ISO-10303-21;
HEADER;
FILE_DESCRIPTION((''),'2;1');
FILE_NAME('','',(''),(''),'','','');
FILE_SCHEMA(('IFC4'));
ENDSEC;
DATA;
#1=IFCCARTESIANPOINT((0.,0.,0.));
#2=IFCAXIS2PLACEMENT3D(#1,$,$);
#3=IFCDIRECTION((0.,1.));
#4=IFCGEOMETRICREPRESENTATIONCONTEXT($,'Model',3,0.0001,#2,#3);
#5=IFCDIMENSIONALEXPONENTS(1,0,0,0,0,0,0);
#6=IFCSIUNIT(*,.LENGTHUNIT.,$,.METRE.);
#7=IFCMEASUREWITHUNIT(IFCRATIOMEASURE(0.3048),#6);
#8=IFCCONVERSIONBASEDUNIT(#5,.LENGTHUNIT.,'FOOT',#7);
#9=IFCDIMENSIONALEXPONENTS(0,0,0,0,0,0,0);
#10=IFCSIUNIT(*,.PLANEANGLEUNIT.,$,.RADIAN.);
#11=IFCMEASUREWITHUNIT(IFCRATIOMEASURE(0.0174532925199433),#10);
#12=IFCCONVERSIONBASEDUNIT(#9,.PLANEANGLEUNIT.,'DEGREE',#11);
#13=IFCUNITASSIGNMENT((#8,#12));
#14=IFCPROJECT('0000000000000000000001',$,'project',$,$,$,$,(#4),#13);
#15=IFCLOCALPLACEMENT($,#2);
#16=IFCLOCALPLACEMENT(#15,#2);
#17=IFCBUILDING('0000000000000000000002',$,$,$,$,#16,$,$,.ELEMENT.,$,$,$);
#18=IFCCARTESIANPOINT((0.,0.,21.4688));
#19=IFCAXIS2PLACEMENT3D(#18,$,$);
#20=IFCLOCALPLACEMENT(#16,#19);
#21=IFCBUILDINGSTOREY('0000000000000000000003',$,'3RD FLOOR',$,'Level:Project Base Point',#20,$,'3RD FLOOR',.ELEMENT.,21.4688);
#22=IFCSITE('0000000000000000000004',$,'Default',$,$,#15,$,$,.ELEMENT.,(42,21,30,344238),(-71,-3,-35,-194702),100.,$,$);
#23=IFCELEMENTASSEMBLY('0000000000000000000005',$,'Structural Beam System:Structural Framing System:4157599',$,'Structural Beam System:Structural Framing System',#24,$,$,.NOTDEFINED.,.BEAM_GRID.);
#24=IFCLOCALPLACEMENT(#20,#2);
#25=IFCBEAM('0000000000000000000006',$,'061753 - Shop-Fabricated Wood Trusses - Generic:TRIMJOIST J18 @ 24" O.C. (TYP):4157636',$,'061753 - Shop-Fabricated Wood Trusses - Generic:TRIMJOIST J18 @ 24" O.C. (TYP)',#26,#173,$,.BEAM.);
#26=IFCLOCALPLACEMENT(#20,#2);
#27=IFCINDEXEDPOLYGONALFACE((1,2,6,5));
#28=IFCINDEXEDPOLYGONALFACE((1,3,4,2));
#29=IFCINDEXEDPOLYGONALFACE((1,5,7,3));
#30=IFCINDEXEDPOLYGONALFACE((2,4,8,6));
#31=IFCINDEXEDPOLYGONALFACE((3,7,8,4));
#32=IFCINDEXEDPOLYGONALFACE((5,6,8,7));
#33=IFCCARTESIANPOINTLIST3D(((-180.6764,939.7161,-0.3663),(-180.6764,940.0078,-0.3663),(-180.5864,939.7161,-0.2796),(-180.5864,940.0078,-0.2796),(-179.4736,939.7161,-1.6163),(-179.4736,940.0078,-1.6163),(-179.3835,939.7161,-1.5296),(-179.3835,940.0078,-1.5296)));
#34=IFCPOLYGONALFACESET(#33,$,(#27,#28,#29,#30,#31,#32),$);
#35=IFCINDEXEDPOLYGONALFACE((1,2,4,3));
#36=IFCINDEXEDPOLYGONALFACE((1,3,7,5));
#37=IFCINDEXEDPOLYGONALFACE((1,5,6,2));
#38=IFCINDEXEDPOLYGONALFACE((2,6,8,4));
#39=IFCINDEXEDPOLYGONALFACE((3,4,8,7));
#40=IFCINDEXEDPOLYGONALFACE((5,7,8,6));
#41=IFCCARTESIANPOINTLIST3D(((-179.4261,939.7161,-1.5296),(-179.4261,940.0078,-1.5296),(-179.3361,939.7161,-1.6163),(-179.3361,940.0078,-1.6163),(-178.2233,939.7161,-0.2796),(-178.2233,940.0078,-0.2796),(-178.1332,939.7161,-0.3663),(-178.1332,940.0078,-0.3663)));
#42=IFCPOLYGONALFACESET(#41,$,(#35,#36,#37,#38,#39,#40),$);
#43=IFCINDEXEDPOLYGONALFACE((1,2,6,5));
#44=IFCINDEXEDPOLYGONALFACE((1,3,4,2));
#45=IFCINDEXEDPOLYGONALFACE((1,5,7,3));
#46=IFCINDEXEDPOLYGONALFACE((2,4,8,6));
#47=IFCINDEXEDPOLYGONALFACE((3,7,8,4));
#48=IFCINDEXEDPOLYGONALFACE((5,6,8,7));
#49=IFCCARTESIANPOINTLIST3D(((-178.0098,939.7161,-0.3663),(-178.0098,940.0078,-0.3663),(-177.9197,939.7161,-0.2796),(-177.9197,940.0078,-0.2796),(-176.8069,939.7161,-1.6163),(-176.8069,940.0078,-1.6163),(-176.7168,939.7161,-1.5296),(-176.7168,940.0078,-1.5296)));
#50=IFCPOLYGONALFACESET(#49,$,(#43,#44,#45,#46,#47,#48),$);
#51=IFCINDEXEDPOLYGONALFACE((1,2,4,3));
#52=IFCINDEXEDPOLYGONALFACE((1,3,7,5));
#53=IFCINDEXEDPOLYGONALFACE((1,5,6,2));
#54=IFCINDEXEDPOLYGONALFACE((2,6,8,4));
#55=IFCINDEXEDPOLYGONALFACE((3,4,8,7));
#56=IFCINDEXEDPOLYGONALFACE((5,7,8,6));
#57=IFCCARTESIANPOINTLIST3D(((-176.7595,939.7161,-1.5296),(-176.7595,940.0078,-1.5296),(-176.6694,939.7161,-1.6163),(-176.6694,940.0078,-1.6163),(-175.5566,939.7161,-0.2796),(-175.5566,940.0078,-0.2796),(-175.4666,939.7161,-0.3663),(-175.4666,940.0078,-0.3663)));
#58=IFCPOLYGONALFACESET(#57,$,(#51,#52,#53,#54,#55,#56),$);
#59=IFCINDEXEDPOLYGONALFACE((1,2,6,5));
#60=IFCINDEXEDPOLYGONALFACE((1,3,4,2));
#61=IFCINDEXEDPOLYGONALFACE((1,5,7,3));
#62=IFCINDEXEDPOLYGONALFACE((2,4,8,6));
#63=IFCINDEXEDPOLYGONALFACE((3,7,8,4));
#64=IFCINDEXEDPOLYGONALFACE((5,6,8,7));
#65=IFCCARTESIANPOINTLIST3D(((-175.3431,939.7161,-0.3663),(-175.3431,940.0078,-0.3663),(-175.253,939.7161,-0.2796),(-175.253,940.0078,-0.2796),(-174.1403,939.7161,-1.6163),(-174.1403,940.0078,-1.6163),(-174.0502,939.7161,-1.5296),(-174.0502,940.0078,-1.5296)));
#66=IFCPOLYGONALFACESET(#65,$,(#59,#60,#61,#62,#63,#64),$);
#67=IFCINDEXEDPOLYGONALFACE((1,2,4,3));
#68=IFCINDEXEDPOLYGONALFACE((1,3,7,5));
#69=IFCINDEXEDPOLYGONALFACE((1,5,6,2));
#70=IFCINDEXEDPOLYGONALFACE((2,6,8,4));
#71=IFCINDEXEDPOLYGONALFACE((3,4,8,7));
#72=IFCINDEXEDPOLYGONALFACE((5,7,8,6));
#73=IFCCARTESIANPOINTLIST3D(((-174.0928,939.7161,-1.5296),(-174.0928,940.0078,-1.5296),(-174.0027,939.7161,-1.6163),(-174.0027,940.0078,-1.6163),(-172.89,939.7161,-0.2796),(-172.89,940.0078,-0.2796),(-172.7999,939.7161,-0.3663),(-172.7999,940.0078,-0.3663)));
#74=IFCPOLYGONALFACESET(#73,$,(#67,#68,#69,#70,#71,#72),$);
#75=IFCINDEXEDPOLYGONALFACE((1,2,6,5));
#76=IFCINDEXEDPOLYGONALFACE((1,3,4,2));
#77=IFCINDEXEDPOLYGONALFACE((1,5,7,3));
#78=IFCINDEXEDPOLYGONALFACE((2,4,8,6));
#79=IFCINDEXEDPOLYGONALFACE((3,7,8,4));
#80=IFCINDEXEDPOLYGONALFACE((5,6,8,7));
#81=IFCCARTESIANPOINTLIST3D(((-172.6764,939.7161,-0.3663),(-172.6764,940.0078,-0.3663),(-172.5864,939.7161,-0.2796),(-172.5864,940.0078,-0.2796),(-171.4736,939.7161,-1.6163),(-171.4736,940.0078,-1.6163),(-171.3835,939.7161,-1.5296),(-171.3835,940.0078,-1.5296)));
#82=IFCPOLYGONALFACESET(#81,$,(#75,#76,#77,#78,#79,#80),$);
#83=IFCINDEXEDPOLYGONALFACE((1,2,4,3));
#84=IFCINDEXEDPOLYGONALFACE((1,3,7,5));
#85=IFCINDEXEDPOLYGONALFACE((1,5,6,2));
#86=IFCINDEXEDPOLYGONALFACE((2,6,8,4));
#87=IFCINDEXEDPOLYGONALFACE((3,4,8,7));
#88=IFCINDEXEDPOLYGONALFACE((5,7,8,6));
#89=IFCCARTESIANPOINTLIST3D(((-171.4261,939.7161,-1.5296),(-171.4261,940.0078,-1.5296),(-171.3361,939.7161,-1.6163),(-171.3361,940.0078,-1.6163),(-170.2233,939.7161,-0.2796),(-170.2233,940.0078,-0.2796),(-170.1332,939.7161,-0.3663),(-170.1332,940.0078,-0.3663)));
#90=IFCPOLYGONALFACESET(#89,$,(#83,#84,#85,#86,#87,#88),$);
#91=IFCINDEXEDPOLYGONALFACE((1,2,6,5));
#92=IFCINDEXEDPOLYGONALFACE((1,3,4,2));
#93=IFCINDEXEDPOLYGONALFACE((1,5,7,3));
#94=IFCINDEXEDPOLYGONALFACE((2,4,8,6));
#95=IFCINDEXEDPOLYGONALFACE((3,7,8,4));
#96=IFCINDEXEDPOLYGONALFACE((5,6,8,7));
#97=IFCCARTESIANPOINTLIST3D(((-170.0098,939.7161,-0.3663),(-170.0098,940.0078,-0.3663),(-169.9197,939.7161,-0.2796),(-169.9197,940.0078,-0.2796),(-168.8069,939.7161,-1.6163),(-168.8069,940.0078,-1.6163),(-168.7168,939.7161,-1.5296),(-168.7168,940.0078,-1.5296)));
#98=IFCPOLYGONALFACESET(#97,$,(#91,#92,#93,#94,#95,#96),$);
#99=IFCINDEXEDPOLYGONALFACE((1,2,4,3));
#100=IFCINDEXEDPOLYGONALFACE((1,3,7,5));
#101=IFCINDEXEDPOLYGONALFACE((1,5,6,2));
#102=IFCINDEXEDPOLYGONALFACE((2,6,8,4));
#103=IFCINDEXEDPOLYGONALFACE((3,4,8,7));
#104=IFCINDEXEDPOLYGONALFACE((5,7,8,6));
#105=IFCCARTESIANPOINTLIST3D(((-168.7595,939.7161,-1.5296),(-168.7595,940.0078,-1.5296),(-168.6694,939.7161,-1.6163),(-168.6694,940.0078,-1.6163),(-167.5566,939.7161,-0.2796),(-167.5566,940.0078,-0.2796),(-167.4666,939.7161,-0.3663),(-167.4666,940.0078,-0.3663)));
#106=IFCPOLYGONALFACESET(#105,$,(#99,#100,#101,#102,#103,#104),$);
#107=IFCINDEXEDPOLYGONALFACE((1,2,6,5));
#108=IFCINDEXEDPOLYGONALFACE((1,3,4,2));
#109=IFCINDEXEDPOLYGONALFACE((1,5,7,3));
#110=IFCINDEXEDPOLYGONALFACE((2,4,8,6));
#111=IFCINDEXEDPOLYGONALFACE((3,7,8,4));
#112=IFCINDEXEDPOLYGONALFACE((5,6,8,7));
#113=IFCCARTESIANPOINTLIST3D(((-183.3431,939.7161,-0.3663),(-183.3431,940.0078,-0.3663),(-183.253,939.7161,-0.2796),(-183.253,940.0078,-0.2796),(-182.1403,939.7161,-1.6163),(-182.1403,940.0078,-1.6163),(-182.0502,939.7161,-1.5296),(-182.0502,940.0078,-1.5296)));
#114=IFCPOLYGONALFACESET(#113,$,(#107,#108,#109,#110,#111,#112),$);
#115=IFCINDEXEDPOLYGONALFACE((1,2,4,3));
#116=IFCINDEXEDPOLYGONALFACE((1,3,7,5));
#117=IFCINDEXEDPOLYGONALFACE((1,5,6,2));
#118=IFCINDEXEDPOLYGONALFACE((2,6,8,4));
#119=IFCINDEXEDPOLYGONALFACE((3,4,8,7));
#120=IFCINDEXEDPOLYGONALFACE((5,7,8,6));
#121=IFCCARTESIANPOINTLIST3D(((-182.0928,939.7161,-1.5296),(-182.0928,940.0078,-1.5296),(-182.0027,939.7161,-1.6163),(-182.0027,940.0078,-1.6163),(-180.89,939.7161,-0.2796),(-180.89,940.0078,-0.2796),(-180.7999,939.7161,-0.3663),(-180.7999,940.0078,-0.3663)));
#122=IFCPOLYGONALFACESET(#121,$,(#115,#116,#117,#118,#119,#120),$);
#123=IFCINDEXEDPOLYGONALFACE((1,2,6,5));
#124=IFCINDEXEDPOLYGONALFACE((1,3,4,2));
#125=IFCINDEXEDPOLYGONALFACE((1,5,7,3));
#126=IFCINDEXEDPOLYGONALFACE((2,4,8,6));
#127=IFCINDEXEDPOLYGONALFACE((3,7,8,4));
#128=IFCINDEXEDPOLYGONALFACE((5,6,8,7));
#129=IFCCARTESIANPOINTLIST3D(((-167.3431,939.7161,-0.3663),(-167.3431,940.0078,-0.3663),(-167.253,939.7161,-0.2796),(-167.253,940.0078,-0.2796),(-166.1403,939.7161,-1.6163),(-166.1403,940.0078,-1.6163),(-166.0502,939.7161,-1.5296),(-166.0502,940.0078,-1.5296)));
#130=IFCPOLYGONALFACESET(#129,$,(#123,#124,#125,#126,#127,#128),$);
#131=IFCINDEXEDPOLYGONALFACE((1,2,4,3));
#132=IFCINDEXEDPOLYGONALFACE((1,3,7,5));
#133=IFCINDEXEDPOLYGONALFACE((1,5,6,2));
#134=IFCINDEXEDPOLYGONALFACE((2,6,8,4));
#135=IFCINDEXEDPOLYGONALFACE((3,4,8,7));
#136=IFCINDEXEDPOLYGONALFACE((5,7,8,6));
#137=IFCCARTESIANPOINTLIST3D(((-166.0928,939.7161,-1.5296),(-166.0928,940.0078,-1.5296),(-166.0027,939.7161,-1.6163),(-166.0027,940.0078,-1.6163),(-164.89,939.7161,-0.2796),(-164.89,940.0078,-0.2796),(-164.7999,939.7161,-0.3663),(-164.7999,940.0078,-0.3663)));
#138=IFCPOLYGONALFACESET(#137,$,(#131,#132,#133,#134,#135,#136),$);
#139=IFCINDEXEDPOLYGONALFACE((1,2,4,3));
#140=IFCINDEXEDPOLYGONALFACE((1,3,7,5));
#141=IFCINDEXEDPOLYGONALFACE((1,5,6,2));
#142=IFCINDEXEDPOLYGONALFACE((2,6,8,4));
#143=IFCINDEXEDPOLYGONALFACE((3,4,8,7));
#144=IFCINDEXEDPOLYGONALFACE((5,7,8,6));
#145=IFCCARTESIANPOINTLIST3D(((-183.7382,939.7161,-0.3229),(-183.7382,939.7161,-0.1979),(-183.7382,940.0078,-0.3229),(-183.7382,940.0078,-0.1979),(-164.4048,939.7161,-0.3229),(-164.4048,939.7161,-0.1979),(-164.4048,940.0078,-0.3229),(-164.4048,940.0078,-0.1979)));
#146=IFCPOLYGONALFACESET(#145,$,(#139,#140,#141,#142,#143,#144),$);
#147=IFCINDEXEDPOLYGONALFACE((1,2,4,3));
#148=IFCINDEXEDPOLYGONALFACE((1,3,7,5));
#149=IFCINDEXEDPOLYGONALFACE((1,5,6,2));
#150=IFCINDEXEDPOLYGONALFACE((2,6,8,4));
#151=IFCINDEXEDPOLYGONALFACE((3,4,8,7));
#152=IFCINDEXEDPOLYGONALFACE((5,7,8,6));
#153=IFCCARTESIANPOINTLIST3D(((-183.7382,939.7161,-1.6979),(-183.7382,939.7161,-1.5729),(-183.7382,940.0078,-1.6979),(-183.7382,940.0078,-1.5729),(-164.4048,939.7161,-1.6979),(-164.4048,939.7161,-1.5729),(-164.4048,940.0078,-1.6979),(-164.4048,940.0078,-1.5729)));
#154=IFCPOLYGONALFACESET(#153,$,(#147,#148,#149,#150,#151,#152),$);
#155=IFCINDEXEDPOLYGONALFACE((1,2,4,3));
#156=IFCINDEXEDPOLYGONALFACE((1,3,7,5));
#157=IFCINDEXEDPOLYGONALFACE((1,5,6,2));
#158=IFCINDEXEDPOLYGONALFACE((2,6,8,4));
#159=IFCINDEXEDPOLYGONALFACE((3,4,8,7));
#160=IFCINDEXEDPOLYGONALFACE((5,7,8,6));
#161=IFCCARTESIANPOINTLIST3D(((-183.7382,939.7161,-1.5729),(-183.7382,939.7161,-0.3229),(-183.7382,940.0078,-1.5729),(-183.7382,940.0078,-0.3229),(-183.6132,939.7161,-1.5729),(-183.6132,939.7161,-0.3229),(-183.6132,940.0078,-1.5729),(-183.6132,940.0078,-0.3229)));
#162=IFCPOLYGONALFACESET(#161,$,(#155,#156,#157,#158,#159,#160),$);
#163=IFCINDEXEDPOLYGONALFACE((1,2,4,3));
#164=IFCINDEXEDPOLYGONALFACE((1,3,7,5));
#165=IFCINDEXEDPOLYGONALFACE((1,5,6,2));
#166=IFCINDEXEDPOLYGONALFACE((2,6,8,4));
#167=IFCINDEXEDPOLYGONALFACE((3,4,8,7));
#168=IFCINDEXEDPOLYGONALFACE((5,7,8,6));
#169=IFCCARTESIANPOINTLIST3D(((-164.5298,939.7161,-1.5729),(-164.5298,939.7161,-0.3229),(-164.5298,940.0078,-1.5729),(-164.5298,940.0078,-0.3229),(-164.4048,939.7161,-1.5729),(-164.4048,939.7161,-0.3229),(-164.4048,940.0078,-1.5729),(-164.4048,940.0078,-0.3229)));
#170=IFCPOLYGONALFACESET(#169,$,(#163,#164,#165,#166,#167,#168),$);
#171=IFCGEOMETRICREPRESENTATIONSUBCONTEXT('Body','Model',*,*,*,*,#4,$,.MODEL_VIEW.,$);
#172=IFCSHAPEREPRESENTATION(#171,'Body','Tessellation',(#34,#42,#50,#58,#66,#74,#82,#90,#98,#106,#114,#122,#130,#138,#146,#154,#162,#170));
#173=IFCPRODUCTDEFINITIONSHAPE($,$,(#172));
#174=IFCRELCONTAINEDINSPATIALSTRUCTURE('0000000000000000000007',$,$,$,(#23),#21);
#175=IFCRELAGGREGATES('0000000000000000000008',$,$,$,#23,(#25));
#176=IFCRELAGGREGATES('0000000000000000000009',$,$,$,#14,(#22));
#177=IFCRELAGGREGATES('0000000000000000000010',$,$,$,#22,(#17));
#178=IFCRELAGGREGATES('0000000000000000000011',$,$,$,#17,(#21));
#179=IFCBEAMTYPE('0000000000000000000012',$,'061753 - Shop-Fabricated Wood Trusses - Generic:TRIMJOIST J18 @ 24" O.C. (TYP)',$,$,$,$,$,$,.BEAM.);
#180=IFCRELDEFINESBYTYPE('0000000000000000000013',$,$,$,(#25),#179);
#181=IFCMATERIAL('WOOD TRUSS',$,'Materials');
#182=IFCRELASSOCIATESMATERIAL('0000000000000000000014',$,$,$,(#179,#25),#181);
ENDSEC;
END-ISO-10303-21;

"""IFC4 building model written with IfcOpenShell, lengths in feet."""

from ifc_helpers import new_model, entity, si_unit, converted_unit, direction, frame, frame_2d, origin, origin_2d_with_axis, place, context, subcontext, project, spatial, rectangle, extrude, source, transform, mapped, material, material_profile, profile_set, profile_usage, type_object, type_shapes, element, aggregate, save


model = new_model("IFC4")

# Units and contexts
model_context = context("Model", 3, precision=0.0001, world=origin(), true_north=direction((0.0, 1.0)))
body_context = subcontext(model_context, "Body", "Model", "MODEL_VIEW")
ifc_project = project(units=[converted_unit("LENGTHUNIT", "FOOT", entity("IfcRatioMeasure", 0.3048), si_unit("LENGTHUNIT", "METRE"), dimensions=[1, 0, 0, 0, 0, 0, 0]), converted_unit("PLANEANGLEUNIT", "DEGREE", entity("IfcRatioMeasure", 0.0174532925199433), si_unit("PLANEANGLEUNIT", "RADIAN"), dimensions=[0, 0, 0, 0, 0, 0, 0])], contexts=[model_context])

# Site, building, storey
site_placement = place(None, origin())
site = spatial("IfcSite", under=ifc_project, at=site_placement, Name="Default", CompositionType="ELEMENT", RefLatitude=(42, 21, 30, 344238), RefLongitude=(-71, -3, -35, -194702), RefElevation=100.0)
building_placement = place(site_placement, origin())
building = spatial("IfcBuilding", under=site, at=building_placement, CompositionType="ELEMENT")
storey_placement = place(building_placement, frame((0.0, 0.0, 21.4688)))
storey = spatial("IfcBuildingStorey", under=building, at=storey_placement, Name="3RD FLOOR", ObjectType="Level:Project Base Point", LongName="3RD FLOOR", CompositionType="ELEMENT", Elevation=21.4688)

# Element assembly, beam
ifc_material = material(Name="WOOD TRUSS", Category="Materials")
ifc_material_profile_1 = material_profile(ifc_material, rectangle(XDim=1.7347, YDim=0.125, at=frame_2d((0.0, 0.0), x_axis=(1.0, 0.0))), Name="TRIMJOIST J18 @ 24\" O.C. (TYP)")
ifc_material_profile_2 = material_profile(ifc_material, rectangle(XDim=1.7347, YDim=0.125, at=frame_2d((0.0, 0.0), x_axis=(1.0, 0.0))), Name="TRIMJOIST J18 @ 24\" O.C. (TYP)")
ifc_material_profile_3 = material_profile(ifc_material, rectangle(XDim=1.7347, YDim=0.125, at=frame_2d((0.0, 0.0), x_axis=(1.0, 0.0))), Name="TRIMJOIST J18 @ 24\" O.C. (TYP)")
ifc_material_profile_4 = material_profile(ifc_material, rectangle(XDim=1.7347, YDim=0.125, at=frame_2d((0.0, 0.0), x_axis=(1.0, 0.0))), Name="TRIMJOIST J18 @ 24\" O.C. (TYP)")
ifc_material_profile_5 = material_profile(ifc_material, rectangle(XDim=1.7347, YDim=0.125, at=frame_2d((0.0, 0.0), x_axis=(1.0, 0.0))), Name="TRIMJOIST J18 @ 24\" O.C. (TYP)")
ifc_material_profile_6 = material_profile(ifc_material, rectangle(XDim=1.7347, YDim=0.125, at=frame_2d((0.0, 0.0), x_axis=(1.0, 0.0))), Name="TRIMJOIST J18 @ 24\" O.C. (TYP)")
ifc_material_profile_7 = material_profile(ifc_material, rectangle(XDim=1.7347, YDim=0.125, at=frame_2d((0.0, 0.0), x_axis=(1.0, 0.0))), Name="TRIMJOIST J18 @ 24\" O.C. (TYP)")
ifc_material_profile_8 = material_profile(ifc_material, rectangle(XDim=1.7347, YDim=0.125, at=frame_2d((0.0, 0.0), x_axis=(1.0, 0.0))), Name="TRIMJOIST J18 @ 24\" O.C. (TYP)")
ifc_material_profile_9 = material_profile(ifc_material, rectangle(XDim=1.7347, YDim=0.125, at=frame_2d((0.0, 0.0), x_axis=(1.0, 0.0))), Name="TRIMJOIST J18 @ 24\" O.C. (TYP)")
ifc_material_profile_10 = material_profile(ifc_material, rectangle(XDim=1.7347, YDim=0.125, at=origin_2d_with_axis()), Name="TRIMJOIST J18 @ 24\" O.C. (TYP)")
ifc_material_profile_11 = material_profile(ifc_material, rectangle(XDim=0.125, YDim=0.2917, at=origin_2d_with_axis()), Name="TRIMJOIST J18 @ 24\" O.C. (TYP)")
ifc_material_profile_12 = material_profile(ifc_material, rectangle(XDim=0.125, YDim=0.2917, at=origin_2d_with_axis()), Name="TRIMJOIST J18 @ 24\" O.C. (TYP)")
ifc_material_profile_13 = material_profile(ifc_material, rectangle(XDim=1.25, YDim=0.2917, at=origin_2d_with_axis()), Name="TRIMJOIST J18 @ 24\" O.C. (TYP)")
ifc_material_profile_14 = material_profile(ifc_material, rectangle(XDim=1.25, YDim=0.2917, at=origin_2d_with_axis()), Name="TRIMJOIST J18 @ 24\" O.C. (TYP)")
ifc_profile_set = profile_set([ifc_material_profile_1, ifc_material_profile_2, ifc_material_profile_3, ifc_material_profile_4, ifc_material_profile_5, ifc_material_profile_6, ifc_material_profile_7, ifc_material_profile_8, ifc_material_profile_9, ifc_material_profile_10, ifc_material_profile_11, ifc_material_profile_12, ifc_material_profile_13, ifc_material_profile_14], Name="TRIMJOIST J18 @ 24\" O.C. (TYP)")
assembly_1_placement = place(storey_placement, origin())
assembly_1 = element("IfcElementAssembly", 1, at=assembly_1_placement, inside=storey, Name="Structural Beam System:Structural Framing System:4157599", ObjectType="Structural Beam System:Structural Framing System", AssemblyPlace="NOTDEFINED", PredefinedType="BEAM_GRID")
beam_type_1 = type_object("IfcBeamType", Name="061753 - Shop-Fabricated Wood Trusses - Generic:TRIMJOIST J18 @ 24\" O.C. (TYP)", PredefinedType="BEAM", material=ifc_profile_set)
shared_shape_1 = source(origin(), body_context, "Body", "SweptSolid", [
    extrude(rectangle(XDim=1.7347, YDim=0.125, at=frame_2d((0.0, 0.0), x_axis=(1.0, 0.0))), frame((5.9585, -0.1458, 0.0), z_axis=(0.0, 1.0, 0.0), x_axis=(0.693383, 0.0, 0.720569)), (0.0, 0.0, 1.0), 0.2917),
    extrude(rectangle(XDim=1.7347, YDim=0.125, at=origin_2d_with_axis()), frame((4.7082, -0.1458, 0.0), z_axis=(0.0, 1.0, 0.0), x_axis=(0.693383, 0.0, -0.720569)), (0.0, 0.0, 1.0), 0.2917),
    extrude(rectangle(XDim=1.7347, YDim=0.125, at=frame_2d((0.0, 0.0), x_axis=(1.0, 0.0))), frame((3.2918, -0.1458, 0.0), z_axis=(0.0, 1.0, 0.0), x_axis=(0.693383, 0.0, 0.720569)), (0.0, 0.0, 1.0), 0.2917),
    extrude(rectangle(XDim=1.7347, YDim=0.125, at=frame_2d((0.0, 0.0), x_axis=(1.0, 0.0))), frame((2.0415, -0.1458, 0.0), z_axis=(0.0, 1.0, 0.0), x_axis=(0.693383, 0.0, -0.720569)), (0.0, 0.0, 1.0), 0.2917),
    extrude(rectangle(XDim=1.7347, YDim=0.125, at=frame_2d((0.0, 0.0), x_axis=(1.0, 0.0))), frame((0.6251, -0.1458, 0.0), z_axis=(0.0, 1.0, 0.0), x_axis=(0.693383, 0.0, 0.720569)), (0.0, 0.0, 1.0), 0.2917),
    extrude(rectangle(XDim=1.7347, YDim=0.125, at=frame_2d((0.0, 0.0), x_axis=(1.0, 0.0))), frame((-0.6251, -0.1458, 0.0), z_axis=(0.0, 1.0, 0.0), x_axis=(0.693383, 0.0, -0.720569)), (0.0, 0.0, 1.0), 0.2917),
    extrude(rectangle(XDim=1.7347, YDim=0.125, at=frame_2d((0.0, 0.0), x_axis=(1.0, 0.0))), frame((-2.0415, -0.1458, 0.0), z_axis=(0.0, 1.0, 0.0), x_axis=(0.693383, 0.0, 0.720569)), (0.0, 0.0, 1.0), 0.2917),
    extrude(rectangle(XDim=1.7347, YDim=0.125, at=origin_2d_with_axis()), frame((-3.2918, -0.1458, 0.0), z_axis=(0.0, 1.0, 0.0), x_axis=(0.693383, 0.0, -0.720569)), (0.0, 0.0, 1.0), 0.2917),
    extrude(rectangle(XDim=1.7347, YDim=0.125, at=frame_2d((0.0, 0.0), x_axis=(1.0, 0.0))), frame((-4.7082, -0.1458, 0.0), z_axis=(0.0, 1.0, 0.0), x_axis=(0.693383, 0.0, 0.720569)), (0.0, 0.0, 1.0), 0.2917),
    extrude(rectangle(XDim=1.7347, YDim=0.125, at=frame_2d((0.0, 0.0), x_axis=(1.0, 0.0))), frame((-5.9585, -0.1458, 0.0), z_axis=(0.0, 1.0, 0.0), x_axis=(0.693383, 0.0, -0.720569)), (0.0, 0.0, 1.0), 0.2917),
    extrude(rectangle(XDim=1.7347, YDim=0.125, at=frame_2d((0.0, 0.0), x_axis=(1.0, 0.0))), frame((8.6251, -0.1458, 0.0), z_axis=(0.0, 1.0, 0.0), x_axis=(0.693383, 0.0, 0.720569)), (0.0, 0.0, 1.0), 0.2917),
    extrude(rectangle(XDim=1.7347, YDim=0.125, at=origin_2d_with_axis()), frame((7.3749, -0.1458, 0.0), z_axis=(0.0, 1.0, 0.0), x_axis=(0.693383, 0.0, -0.720569)), (0.0, 0.0, 1.0), 0.2917),
    extrude(rectangle(XDim=1.7347, YDim=0.125, at=frame_2d((0.0, 0.0), x_axis=(1.0, 0.0))), frame((-7.3749, -0.1458, 0.0), z_axis=(0.0, 1.0, 0.0), x_axis=(0.693383, 0.0, 0.720569)), (0.0, 0.0, 1.0), 0.2917),
    extrude(rectangle(XDim=1.7347, YDim=0.125, at=origin_2d_with_axis()), frame((-8.6251, -0.1458, 0.0), z_axis=(0.0, 1.0, 0.0), x_axis=(0.693383, 0.0, -0.720569)), (0.0, 0.0, 1.0), 0.2917),
    extrude(rectangle(XDim=0.125, YDim=0.2917, at=origin_2d_with_axis()), frame((-9.6667, 0.0, 0.6875), z_axis=(1.0, 0.0, 0.0), x_axis=(0.0, 0.0, -1.0)), (0.0, 0.0, 1.0), 19.3333),
    extrude(rectangle(XDim=0.125, YDim=0.2917, at=origin_2d_with_axis()), frame((-9.6667, 0.0, -0.6875), z_axis=(1.0, 0.0, 0.0), x_axis=(0.0, 0.0, -1.0)), (0.0, 0.0, 1.0), 19.3333),
    extrude(rectangle(XDim=1.25, YDim=0.2917, at=origin_2d_with_axis()), frame((9.5417, 0.0, 0.0), z_axis=(1.0, 0.0, 0.0), x_axis=(0.0, 0.0, -1.0)), (0.0, 0.0, 1.0), 0.125),
    extrude(rectangle(XDim=1.25, YDim=0.2917, at=origin_2d_with_axis()), frame((-9.6667, 0.0, 0.0), z_axis=(1.0, 0.0, 0.0), x_axis=(0.0, 0.0, -1.0)), (0.0, 0.0, 1.0), 0.125),
])
type_shapes(beam_type_1, [shared_shape_1])
ifc_profile_usage_1 = profile_usage(ifc_profile_set, cardinal=8)
beam_1_placement = place(assembly_1_placement, frame((-174.0715, 939.8619, -0.9479), z_axis=(0.0, 0.0, 1.0), x_axis=(-1.0, 0.0, 0.0)))
beam_1 = element("IfcBeam", 2, at=beam_1_placement, type_object=beam_type_1, material=ifc_profile_usage_1, Name="061753 - Shop-Fabricated Wood Trusses - Generic:TRIMJOIST J18 @ 24\" O.C. (TYP):4157636", ObjectType="061753 - Shop-Fabricated Wood Trusses - Generic:TRIMJOIST J18 @ 24\" O.C. (TYP)", PredefinedType="BEAM", context=body_context, shape_type="MappedRepresentation", body=[
    mapped(shared_shape_1, transform((0.0, 0.0, 0.0), scale=1.0)),
])
aggregate(assembly_1, [beam_1])

save(model, "model.ifc")
